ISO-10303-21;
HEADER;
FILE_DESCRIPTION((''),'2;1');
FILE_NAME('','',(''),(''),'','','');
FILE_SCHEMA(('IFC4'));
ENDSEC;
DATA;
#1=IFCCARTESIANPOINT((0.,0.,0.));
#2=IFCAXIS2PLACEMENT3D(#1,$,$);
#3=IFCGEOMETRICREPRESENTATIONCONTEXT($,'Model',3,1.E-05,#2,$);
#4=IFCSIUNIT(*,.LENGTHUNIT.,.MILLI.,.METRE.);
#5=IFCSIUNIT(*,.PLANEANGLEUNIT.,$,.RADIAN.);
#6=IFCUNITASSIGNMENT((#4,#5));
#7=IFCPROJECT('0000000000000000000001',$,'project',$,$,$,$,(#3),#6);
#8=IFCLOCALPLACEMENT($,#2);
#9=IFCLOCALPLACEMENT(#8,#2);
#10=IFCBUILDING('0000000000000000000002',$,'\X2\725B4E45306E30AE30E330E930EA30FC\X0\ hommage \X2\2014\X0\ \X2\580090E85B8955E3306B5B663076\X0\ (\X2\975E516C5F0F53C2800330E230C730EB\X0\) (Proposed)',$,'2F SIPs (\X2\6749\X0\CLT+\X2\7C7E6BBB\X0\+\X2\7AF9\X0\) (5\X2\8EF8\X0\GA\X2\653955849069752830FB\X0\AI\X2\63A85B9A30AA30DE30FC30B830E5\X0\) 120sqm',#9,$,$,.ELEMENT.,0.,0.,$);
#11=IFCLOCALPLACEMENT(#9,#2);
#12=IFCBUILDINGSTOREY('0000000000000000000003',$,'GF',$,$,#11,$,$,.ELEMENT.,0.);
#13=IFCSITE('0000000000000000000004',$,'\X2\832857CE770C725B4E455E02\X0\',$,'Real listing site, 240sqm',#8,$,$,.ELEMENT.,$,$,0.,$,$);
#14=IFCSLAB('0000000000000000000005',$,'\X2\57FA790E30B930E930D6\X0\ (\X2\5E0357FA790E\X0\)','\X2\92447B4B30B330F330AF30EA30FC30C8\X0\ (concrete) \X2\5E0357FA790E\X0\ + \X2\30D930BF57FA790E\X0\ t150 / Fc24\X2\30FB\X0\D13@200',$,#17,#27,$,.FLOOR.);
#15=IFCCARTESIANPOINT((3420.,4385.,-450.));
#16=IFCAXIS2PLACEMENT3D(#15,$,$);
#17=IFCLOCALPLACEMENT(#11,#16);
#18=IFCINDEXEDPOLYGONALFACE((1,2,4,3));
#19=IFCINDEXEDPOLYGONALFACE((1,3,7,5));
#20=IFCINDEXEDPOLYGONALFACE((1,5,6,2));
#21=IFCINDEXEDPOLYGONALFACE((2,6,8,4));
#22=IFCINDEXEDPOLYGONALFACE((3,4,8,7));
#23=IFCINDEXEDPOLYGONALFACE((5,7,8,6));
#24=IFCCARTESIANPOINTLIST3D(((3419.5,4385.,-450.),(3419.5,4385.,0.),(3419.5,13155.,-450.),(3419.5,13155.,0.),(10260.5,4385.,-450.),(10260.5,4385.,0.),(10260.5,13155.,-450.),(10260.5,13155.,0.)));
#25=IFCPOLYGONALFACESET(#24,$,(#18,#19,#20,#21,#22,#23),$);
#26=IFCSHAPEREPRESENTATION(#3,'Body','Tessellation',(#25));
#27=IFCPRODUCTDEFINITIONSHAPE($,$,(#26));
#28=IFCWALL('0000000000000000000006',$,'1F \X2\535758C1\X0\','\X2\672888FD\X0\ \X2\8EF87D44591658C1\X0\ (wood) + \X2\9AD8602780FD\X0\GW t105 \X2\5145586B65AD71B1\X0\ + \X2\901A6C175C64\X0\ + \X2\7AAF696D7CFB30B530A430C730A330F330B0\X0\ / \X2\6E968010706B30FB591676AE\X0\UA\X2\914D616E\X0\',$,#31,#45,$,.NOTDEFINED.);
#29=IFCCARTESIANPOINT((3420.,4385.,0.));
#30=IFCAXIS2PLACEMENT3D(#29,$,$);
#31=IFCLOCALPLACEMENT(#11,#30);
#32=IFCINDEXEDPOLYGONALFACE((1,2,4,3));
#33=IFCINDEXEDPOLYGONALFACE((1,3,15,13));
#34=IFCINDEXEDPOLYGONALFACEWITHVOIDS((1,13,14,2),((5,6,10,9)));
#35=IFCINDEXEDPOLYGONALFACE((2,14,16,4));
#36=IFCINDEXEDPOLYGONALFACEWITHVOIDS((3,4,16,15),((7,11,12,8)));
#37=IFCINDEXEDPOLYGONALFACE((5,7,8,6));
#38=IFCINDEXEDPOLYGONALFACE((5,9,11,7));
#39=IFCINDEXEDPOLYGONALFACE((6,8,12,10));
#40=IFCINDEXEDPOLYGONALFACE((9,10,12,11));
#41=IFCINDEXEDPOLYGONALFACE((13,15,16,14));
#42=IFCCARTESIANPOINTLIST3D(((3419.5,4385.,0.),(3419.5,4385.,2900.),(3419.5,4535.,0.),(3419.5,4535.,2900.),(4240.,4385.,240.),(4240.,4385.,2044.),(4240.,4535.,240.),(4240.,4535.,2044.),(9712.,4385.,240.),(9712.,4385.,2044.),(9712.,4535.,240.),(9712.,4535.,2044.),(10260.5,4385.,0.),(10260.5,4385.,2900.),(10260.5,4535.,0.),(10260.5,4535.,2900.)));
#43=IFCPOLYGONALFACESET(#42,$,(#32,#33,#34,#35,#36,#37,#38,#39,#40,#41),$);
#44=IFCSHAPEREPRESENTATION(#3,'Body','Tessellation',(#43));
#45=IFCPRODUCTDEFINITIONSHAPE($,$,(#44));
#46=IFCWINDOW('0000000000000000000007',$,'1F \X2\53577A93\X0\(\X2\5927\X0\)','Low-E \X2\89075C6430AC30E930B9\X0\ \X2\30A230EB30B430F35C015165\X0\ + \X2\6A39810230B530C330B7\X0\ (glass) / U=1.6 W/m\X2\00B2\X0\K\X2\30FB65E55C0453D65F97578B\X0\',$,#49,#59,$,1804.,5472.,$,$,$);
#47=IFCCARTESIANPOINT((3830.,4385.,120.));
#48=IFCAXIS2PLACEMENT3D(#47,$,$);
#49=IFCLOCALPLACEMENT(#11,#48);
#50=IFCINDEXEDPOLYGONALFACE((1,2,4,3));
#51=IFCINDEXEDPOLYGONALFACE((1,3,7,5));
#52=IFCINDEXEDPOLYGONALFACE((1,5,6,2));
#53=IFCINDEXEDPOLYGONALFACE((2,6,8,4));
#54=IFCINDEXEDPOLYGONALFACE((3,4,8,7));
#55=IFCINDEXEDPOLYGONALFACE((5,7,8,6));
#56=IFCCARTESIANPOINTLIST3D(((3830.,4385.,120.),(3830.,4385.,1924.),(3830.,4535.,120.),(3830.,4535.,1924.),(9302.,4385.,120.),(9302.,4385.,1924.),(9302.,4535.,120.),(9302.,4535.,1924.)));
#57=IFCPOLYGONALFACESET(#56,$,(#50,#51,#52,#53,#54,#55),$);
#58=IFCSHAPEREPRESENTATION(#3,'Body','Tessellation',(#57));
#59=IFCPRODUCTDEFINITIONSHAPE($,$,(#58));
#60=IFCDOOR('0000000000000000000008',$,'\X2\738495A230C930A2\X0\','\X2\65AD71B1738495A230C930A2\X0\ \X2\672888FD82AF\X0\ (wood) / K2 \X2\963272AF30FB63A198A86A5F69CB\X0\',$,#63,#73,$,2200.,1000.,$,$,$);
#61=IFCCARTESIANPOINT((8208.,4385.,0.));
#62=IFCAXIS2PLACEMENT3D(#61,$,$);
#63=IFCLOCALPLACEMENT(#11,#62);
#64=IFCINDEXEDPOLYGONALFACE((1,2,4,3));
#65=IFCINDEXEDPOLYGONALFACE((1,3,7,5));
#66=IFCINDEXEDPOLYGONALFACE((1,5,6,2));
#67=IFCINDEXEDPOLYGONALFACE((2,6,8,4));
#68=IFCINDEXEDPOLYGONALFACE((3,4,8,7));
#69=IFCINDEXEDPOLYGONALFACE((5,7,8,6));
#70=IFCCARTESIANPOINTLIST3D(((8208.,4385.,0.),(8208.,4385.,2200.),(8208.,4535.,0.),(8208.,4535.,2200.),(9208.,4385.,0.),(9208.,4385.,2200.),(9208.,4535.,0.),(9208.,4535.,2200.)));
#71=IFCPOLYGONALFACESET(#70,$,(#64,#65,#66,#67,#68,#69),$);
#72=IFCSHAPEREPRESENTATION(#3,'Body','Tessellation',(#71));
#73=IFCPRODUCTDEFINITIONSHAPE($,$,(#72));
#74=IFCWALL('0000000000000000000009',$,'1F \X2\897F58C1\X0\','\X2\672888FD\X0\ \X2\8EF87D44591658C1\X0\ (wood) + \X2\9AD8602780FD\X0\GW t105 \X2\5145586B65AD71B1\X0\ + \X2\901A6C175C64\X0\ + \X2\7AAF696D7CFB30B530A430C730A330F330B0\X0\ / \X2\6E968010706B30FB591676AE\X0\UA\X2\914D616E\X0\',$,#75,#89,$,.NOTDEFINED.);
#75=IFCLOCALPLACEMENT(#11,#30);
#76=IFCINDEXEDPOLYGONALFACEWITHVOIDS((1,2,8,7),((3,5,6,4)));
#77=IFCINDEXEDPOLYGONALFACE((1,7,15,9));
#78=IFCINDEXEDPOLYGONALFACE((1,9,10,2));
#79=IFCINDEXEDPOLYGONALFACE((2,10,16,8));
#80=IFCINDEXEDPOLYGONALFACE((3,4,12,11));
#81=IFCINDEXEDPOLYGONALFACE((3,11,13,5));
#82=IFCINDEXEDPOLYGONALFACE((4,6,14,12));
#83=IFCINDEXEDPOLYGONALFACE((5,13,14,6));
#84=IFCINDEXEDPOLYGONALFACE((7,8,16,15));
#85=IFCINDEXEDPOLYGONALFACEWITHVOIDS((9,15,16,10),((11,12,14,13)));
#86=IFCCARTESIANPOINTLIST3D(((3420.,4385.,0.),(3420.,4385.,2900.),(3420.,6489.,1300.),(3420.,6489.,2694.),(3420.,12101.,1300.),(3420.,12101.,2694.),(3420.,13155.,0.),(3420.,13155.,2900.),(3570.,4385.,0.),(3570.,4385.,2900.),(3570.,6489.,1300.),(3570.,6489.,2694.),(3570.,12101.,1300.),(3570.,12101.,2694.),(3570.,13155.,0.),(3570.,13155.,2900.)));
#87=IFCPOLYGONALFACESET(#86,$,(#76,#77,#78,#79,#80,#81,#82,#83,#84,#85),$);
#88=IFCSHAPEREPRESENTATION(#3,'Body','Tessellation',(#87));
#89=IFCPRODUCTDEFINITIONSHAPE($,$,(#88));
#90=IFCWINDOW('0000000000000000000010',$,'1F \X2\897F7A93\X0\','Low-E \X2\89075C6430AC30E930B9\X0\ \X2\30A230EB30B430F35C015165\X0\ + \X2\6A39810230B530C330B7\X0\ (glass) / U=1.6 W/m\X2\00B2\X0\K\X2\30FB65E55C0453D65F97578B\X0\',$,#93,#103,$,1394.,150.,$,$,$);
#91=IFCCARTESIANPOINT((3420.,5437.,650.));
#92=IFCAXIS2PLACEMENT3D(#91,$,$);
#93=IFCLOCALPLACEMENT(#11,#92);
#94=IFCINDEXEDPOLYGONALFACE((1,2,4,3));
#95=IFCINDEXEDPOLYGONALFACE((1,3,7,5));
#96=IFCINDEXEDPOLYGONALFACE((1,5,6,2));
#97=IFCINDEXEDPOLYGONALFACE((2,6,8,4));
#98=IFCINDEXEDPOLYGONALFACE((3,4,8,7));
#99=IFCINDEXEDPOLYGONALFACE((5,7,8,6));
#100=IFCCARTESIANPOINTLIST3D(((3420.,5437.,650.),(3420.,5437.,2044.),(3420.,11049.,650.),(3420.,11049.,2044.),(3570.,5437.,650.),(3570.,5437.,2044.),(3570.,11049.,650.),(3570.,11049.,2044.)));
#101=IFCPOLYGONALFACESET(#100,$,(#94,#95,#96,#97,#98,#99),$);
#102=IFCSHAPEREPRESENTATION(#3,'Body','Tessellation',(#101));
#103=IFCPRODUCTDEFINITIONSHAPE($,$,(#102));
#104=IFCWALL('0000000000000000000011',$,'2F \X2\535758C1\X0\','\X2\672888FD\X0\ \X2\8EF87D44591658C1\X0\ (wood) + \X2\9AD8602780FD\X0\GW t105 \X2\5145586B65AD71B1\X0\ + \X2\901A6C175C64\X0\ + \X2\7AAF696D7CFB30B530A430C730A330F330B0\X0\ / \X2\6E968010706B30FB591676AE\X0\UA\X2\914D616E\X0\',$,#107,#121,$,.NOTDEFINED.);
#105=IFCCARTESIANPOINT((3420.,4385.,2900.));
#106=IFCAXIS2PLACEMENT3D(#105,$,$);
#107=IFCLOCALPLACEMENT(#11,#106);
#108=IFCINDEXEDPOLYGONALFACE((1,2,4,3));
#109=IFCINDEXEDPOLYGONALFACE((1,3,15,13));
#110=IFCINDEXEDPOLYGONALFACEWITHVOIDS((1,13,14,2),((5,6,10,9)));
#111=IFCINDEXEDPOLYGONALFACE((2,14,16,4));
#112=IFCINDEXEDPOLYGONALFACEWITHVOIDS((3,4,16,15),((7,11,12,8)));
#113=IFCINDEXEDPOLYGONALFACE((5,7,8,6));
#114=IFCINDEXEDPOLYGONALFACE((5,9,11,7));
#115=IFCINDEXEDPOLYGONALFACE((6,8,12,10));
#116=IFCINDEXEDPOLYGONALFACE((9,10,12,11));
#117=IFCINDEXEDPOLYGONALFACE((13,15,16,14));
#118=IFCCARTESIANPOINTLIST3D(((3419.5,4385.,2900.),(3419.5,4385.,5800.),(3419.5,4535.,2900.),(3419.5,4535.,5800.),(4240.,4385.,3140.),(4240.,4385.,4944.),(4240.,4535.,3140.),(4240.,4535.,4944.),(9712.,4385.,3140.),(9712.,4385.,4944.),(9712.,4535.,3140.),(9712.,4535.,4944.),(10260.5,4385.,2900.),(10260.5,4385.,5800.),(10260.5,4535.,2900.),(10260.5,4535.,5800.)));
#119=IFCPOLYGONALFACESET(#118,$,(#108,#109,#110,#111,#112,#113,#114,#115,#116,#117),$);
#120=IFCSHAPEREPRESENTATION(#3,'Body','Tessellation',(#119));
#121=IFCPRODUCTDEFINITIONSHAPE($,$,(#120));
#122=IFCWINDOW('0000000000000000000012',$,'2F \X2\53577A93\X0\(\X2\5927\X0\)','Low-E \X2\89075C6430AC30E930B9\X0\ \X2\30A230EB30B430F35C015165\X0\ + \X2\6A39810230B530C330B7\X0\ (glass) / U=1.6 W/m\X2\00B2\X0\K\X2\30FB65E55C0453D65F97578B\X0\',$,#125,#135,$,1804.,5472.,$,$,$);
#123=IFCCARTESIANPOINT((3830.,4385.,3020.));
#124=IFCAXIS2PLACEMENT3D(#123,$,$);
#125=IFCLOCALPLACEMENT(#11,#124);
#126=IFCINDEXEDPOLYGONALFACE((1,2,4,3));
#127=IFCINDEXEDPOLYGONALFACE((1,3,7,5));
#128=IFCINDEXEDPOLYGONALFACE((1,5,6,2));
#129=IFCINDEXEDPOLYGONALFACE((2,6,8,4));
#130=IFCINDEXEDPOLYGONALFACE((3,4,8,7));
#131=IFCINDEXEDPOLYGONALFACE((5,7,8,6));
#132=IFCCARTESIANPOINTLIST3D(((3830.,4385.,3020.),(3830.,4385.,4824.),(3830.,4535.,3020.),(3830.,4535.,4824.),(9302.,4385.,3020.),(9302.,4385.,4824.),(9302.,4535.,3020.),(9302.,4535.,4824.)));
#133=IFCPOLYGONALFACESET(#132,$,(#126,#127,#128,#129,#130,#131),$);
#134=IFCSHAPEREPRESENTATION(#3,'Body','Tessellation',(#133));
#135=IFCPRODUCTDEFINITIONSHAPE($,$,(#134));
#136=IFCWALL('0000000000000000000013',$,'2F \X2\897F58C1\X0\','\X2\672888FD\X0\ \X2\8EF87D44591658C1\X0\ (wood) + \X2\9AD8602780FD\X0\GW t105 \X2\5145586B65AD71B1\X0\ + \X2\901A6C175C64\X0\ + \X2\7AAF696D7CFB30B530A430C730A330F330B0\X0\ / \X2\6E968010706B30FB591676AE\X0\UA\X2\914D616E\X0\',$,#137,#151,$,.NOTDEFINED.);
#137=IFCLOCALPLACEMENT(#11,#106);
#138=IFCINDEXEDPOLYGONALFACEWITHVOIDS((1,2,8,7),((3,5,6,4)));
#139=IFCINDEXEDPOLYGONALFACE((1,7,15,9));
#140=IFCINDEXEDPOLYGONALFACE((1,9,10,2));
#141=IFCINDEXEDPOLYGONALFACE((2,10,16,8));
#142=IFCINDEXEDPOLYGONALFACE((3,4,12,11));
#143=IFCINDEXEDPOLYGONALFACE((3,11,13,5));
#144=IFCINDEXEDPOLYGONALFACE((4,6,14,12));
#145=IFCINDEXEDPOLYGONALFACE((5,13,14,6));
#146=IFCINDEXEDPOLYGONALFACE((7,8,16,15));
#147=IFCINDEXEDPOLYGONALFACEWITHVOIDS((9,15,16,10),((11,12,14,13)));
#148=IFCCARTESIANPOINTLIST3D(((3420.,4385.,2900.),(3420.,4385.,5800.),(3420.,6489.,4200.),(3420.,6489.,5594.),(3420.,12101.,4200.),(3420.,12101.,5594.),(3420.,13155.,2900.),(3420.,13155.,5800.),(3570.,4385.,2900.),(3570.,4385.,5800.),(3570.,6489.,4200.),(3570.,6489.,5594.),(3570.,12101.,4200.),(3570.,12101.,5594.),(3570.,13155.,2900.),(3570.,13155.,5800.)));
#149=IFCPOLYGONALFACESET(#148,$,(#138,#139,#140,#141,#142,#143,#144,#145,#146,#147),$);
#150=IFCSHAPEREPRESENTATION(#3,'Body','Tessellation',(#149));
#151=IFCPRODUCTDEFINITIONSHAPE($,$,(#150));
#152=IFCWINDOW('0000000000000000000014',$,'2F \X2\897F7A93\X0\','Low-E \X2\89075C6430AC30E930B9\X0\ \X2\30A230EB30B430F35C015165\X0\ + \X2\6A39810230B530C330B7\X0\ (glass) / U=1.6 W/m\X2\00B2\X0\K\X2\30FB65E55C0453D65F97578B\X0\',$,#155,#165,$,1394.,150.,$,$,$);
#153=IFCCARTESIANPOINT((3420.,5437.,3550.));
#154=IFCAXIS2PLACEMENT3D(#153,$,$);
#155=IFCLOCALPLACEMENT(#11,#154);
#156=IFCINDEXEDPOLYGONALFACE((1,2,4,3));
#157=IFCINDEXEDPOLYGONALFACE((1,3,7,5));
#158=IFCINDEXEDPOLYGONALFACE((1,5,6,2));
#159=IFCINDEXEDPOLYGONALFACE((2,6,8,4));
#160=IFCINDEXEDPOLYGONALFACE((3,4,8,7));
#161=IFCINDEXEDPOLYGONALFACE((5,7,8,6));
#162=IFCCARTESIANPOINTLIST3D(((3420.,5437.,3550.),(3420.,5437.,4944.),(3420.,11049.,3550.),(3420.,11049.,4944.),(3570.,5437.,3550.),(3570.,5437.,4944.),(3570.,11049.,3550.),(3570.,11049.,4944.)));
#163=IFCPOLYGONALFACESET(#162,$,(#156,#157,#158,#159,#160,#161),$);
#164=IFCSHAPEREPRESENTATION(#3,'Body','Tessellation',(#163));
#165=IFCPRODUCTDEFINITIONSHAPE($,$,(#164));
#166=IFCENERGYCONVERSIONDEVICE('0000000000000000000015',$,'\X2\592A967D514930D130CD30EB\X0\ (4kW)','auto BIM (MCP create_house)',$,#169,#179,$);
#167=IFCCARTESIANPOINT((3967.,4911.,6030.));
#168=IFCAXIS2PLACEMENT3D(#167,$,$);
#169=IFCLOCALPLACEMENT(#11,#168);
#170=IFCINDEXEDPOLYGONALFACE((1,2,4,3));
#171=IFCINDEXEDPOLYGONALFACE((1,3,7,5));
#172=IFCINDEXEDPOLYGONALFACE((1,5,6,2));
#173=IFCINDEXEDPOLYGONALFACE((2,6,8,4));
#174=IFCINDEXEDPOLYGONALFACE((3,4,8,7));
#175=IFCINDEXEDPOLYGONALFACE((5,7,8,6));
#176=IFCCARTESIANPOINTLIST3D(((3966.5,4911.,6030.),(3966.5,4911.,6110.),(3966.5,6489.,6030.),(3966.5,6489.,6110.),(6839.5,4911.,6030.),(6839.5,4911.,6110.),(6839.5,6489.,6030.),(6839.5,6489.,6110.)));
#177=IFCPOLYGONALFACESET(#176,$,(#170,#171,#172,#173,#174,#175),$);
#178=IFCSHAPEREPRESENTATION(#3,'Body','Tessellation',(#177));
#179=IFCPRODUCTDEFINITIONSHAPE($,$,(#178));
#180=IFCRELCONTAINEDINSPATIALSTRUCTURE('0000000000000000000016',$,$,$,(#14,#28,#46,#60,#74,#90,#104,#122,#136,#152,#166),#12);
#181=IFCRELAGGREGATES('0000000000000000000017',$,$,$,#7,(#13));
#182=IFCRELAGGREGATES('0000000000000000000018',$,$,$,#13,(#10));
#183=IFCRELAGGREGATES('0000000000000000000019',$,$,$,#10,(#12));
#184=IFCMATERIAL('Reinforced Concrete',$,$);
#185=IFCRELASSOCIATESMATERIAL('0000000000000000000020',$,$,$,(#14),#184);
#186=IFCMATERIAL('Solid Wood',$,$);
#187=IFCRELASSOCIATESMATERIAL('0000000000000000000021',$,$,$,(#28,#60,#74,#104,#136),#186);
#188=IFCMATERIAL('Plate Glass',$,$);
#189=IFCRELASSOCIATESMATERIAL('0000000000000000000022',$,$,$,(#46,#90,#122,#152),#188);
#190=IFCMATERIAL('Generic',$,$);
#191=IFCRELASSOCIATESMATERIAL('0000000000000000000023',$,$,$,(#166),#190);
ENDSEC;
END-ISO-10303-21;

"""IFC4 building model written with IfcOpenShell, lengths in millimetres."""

from ifc_helpers import new_model, si_unit, frame, frame_2d, origin, place, context, project, spatial, rectangle, extrude, material, element, fill, save


model = new_model("IFC4")

# Units and contexts
model_context = context("Model", 3, precision=1e-05, world=origin())
ifc_project = project(units=[si_unit("LENGTHUNIT", "METRE", prefix="MILLI"), si_unit("PLANEANGLEUNIT", "RADIAN")], contexts=[model_context])

# Site, building, storey
site_placement = place(None, origin())
site = spatial("IfcSite", under=ifc_project, at=site_placement, Name="茨城県牛久市", ObjectType="Real listing site, 240sqm", CompositionType="ELEMENT", RefElevation=0.0)
building_placement = place(site_placement, origin())
building = spatial("IfcBuilding", under=site, at=building_placement, Name="牛久のギャラリー hommage — 堀部安嗣に学ぶ (非公式参考モデル) (Proposed)", ObjectType="2F SIPs (杉CLT+籾殻+竹) (5軸GA改善適用・AI推定オマージュ) 120sqm", CompositionType="ELEMENT", ElevationOfRefHeight=0.0, ElevationOfTerrain=0.0)
storey_placement = place(building_placement, origin())
storey = spatial("IfcBuildingStorey", under=building, at=storey_placement, Name="GF", CompositionType="ELEMENT", Elevation=0.0)

# Slab
ifc_material_1 = material(Name="Reinforced Concrete")
slab_1_placement = place(storey_placement, frame((3420.0, 4385.0, -450.0)))
element("IfcSlab", 1, at=slab_1_placement, inside=storey, material=ifc_material_1, Name="基礎スラブ (布基礎)", Description="鉄筋コンクリート (concrete) 布基礎 + ベタ基礎 t150 / Fc24・D13@200", PredefinedType="FLOOR", context=model_context, shape_type="SweptSolid", body=[
    extrude(rectangle(XDim=6841.0, YDim=8770.0, at=frame_2d((3420.0, 4385.0))), frame((3420.0, 4385.0, -450.0)), (0.0, 0.0, 1.0), 450.0),
])
ifc_material_2 = material(Name="Solid Wood")

# Wall, openings, window, door
wall_1_placement = place(storey_placement, frame((3420.0, 4385.0, 0.0)))
wall_1 = element("IfcWall", 2, at=wall_1_placement, inside=storey, material=ifc_material_2, Name="1F 南壁", Description="木製 軸組外壁 (wood) + 高性能GW t105 充填断熱 + 通気層 + 窯業系サイディング / 準耐火・外皮UA配慮", PredefinedType="NOTDEFINED", context=model_context, shape_type="SweptSolid", body=[
    extrude(rectangle(XDim=6841.0, YDim=150.0, at=frame_2d((3420.0, 75.0))), frame((3420.0, 4385.0, 0.0)), (0.0, 0.0, 1.0), 2900.0),
])
opening_1_placement = place(storey_placement, frame((3830.0, 4385.0, 120.0)))
opening_1 = element("IfcOpeningElement", 3, at=opening_1_placement, cuts=wall_1, PredefinedType="NOTDEFINED", context=model_context, shape_type="SweptSolid", body=[
    extrude(rectangle(XDim=5472.0, YDim=150.0, at=frame_2d((2736.0, 75.0))), frame((3830.0, 4385.0, 120.0)), (0.0, 0.0, 1.0), 1804.0),
])
opening_2_placement = place(storey_placement, frame((8208.0, 4385.0, 0.0)))
opening_2 = element("IfcOpeningElement", 4, at=opening_2_placement, cuts=wall_1, PredefinedType="NOTDEFINED", context=model_context, shape_type="SweptSolid", body=[
    extrude(rectangle(XDim=1000.0, YDim=150.0, at=frame_2d((500.0, 75.0))), frame((8208.0, 4385.0, 0.0)), (0.0, 0.0, 1.0), 2200.0),
])
ifc_material_3 = material(Name="Plate Glass")
window_1_placement = place(storey_placement, frame((3830.0, 4385.0, 120.0)))
window_1 = element("IfcWindow", 5, at=window_1_placement, inside=storey, material=ifc_material_3, Name="1F 南窓(大)", Description="Low-E 複層ガラス アルゴン封入 + 樹脂サッシ (glass) / U=1.6 W/m²K・日射取得型", OverallHeight=1804.0, OverallWidth=5472.0, context=model_context, shape_type="SweptSolid", body=[
    extrude(rectangle(XDim=5472.0, YDim=150.0, at=frame_2d((2736.0, 75.0))), frame((3830.0, 4385.0, 120.0)), (0.0, 0.0, 1.0), 1804.0),
])
fill(opening_1, window_1)
door_placement = place(storey_placement, frame((8208.0, 4385.0, 0.0)))
door = element("IfcDoor", 6, at=door_placement, inside=storey, material=ifc_material_2, Name="玄関ドア", Description="断熱玄関ドア 木製芯 (wood) / K2 防犯・採風機構", OverallHeight=2200.0, OverallWidth=1000.0, context=model_context, shape_type="SweptSolid", body=[
    extrude(rectangle(XDim=1000.0, YDim=150.0, at=frame_2d((500.0, 75.0))), frame((8208.0, 4385.0, 0.0)), (0.0, 0.0, 1.0), 2200.0),
])
fill(opening_2, door)

# Wall, opening, window
wall_2_placement = place(storey_placement, frame((3420.0, 4385.0, 0.0)))
wall_2 = element("IfcWall", 7, at=wall_2_placement, inside=storey, material=ifc_material_2, Name="1F 西壁", Description="木製 軸組外壁 (wood) + 高性能GW t105 充填断熱 + 通気層 + 窯業系サイディング / 準耐火・外皮UA配慮", PredefinedType="NOTDEFINED", context=model_context, shape_type="SweptSolid", body=[
    extrude(rectangle(XDim=150.0, YDim=8770.0, at=frame_2d((75.0, 4385.0))), frame((3420.0, 4385.0, 0.0)), (0.0, 0.0, 1.0), 2900.0),
])
opening_3_placement = place(storey_placement, frame((3420.0, 5437.0, 650.0)))
opening_3 = element("IfcOpeningElement", 8, at=opening_3_placement, cuts=wall_2, PredefinedType="NOTDEFINED", context=model_context, shape_type="SweptSolid", body=[
    extrude(rectangle(XDim=150.0, YDim=5612.0, at=frame_2d((75.0, 2806.0))), frame((3420.0, 5437.0, 650.0)), (0.0, 0.0, 1.0), 1394.0),
])
window_2_placement = place(storey_placement, frame((3420.0, 5437.0, 650.0)))
window_2 = element("IfcWindow", 9, at=window_2_placement, inside=storey, material=ifc_material_3, Name="1F 西窓", Description="Low-E 複層ガラス アルゴン封入 + 樹脂サッシ (glass) / U=1.6 W/m²K・日射取得型", OverallHeight=1394.0, OverallWidth=150.0, context=model_context, shape_type="SweptSolid", body=[
    extrude(rectangle(XDim=150.0, YDim=5612.0, at=frame_2d((75.0, 2806.0))), frame((3420.0, 5437.0, 650.0)), (0.0, 0.0, 1.0), 1394.0),
])
fill(opening_3, window_2)

# Walls, openings, windows
wall_3_placement = place(storey_placement, frame((3420.0, 4385.0, 2900.0)))
wall_3 = element("IfcWall", 10, at=wall_3_placement, inside=storey, material=ifc_material_2, Name="2F 南壁", Description="木製 軸組外壁 (wood) + 高性能GW t105 充填断熱 + 通気層 + 窯業系サイディング / 準耐火・外皮UA配慮", PredefinedType="NOTDEFINED", context=model_context, shape_type="SweptSolid", body=[
    extrude(rectangle(XDim=6841.0, YDim=150.0, at=frame_2d((3420.0, 75.0))), frame((3420.0, 4385.0, 2900.0)), (0.0, 0.0, 1.0), 2900.0),
])
opening_4_placement = place(storey_placement, frame((3830.0, 4385.0, 3020.0)))
opening_4 = element("IfcOpeningElement", 11, at=opening_4_placement, cuts=wall_3, PredefinedType="NOTDEFINED", context=model_context, shape_type="SweptSolid", body=[
    extrude(rectangle(XDim=5472.0, YDim=150.0, at=frame_2d((2736.0, 75.0))), frame((3830.0, 4385.0, 3020.0)), (0.0, 0.0, 1.0), 1804.0),
])
window_3_placement = place(storey_placement, frame((3830.0, 4385.0, 3020.0)))
window_3 = element("IfcWindow", 12, at=window_3_placement, inside=storey, material=ifc_material_3, Name="2F 南窓(大)", Description="Low-E 複層ガラス アルゴン封入 + 樹脂サッシ (glass) / U=1.6 W/m²K・日射取得型", OverallHeight=1804.0, OverallWidth=5472.0, context=model_context, shape_type="SweptSolid", body=[
    extrude(rectangle(XDim=5472.0, YDim=150.0, at=frame_2d((2736.0, 75.0))), frame((3830.0, 4385.0, 3020.0)), (0.0, 0.0, 1.0), 1804.0),
])
fill(opening_4, window_3)
wall_4_placement = place(storey_placement, frame((3420.0, 4385.0, 2900.0)))
wall_4 = element("IfcWall", 13, at=wall_4_placement, inside=storey, material=ifc_material_2, Name="2F 西壁", Description="木製 軸組外壁 (wood) + 高性能GW t105 充填断熱 + 通気層 + 窯業系サイディング / 準耐火・外皮UA配慮", PredefinedType="NOTDEFINED", context=model_context, shape_type="SweptSolid", body=[
    extrude(rectangle(XDim=150.0, YDim=8770.0, at=frame_2d((75.0, 4385.0))), frame((3420.0, 4385.0, 2900.0)), (0.0, 0.0, 1.0), 2900.0),
])
opening_5_placement = place(storey_placement, frame((3420.0, 5437.0, 3550.0)))
opening_5 = element("IfcOpeningElement", 14, at=opening_5_placement, cuts=wall_4, PredefinedType="NOTDEFINED", context=model_context, shape_type="SweptSolid", body=[
    extrude(rectangle(XDim=150.0, YDim=5612.0, at=frame_2d((75.0, 2806.0))), frame((3420.0, 5437.0, 3550.0)), (0.0, 0.0, 1.0), 1394.0),
])
window_4_placement = place(storey_placement, frame((3420.0, 5437.0, 3550.0)))
window_4 = element("IfcWindow", 15, at=window_4_placement, inside=storey, material=ifc_material_3, Name="2F 西窓", Description="Low-E 複層ガラス アルゴン封入 + 樹脂サッシ (glass) / U=1.6 W/m²K・日射取得型", OverallHeight=1394.0, OverallWidth=150.0, context=model_context, shape_type="SweptSolid", body=[
    extrude(rectangle(XDim=150.0, YDim=5612.0, at=frame_2d((75.0, 2806.0))), frame((3420.0, 5437.0, 3550.0)), (0.0, 0.0, 1.0), 1394.0),
])
fill(opening_5, window_4)

# Shared definitions
ifc_material_4 = material(Name="Generic")

# Energy conversion device
energy_conversion_device_placement = place(storey_placement, frame((3967.0, 4911.0, 6030.0)))
element("IfcEnergyConversionDevice", 16, at=energy_conversion_device_placement, inside=storey, material=ifc_material_4, Name="太陽光パネル (4kW)", Description="auto BIM (MCP create_house)", context=model_context, shape_type="SweptSolid", body=[
    extrude(rectangle(XDim=2873.0, YDim=1578.0, at=frame_2d((1436.0, 789.0))), frame((3967.0, 4911.0, 6030.0)), (0.0, 0.0, 1.0), 80.0),
])

save(model, "model.ifc")
